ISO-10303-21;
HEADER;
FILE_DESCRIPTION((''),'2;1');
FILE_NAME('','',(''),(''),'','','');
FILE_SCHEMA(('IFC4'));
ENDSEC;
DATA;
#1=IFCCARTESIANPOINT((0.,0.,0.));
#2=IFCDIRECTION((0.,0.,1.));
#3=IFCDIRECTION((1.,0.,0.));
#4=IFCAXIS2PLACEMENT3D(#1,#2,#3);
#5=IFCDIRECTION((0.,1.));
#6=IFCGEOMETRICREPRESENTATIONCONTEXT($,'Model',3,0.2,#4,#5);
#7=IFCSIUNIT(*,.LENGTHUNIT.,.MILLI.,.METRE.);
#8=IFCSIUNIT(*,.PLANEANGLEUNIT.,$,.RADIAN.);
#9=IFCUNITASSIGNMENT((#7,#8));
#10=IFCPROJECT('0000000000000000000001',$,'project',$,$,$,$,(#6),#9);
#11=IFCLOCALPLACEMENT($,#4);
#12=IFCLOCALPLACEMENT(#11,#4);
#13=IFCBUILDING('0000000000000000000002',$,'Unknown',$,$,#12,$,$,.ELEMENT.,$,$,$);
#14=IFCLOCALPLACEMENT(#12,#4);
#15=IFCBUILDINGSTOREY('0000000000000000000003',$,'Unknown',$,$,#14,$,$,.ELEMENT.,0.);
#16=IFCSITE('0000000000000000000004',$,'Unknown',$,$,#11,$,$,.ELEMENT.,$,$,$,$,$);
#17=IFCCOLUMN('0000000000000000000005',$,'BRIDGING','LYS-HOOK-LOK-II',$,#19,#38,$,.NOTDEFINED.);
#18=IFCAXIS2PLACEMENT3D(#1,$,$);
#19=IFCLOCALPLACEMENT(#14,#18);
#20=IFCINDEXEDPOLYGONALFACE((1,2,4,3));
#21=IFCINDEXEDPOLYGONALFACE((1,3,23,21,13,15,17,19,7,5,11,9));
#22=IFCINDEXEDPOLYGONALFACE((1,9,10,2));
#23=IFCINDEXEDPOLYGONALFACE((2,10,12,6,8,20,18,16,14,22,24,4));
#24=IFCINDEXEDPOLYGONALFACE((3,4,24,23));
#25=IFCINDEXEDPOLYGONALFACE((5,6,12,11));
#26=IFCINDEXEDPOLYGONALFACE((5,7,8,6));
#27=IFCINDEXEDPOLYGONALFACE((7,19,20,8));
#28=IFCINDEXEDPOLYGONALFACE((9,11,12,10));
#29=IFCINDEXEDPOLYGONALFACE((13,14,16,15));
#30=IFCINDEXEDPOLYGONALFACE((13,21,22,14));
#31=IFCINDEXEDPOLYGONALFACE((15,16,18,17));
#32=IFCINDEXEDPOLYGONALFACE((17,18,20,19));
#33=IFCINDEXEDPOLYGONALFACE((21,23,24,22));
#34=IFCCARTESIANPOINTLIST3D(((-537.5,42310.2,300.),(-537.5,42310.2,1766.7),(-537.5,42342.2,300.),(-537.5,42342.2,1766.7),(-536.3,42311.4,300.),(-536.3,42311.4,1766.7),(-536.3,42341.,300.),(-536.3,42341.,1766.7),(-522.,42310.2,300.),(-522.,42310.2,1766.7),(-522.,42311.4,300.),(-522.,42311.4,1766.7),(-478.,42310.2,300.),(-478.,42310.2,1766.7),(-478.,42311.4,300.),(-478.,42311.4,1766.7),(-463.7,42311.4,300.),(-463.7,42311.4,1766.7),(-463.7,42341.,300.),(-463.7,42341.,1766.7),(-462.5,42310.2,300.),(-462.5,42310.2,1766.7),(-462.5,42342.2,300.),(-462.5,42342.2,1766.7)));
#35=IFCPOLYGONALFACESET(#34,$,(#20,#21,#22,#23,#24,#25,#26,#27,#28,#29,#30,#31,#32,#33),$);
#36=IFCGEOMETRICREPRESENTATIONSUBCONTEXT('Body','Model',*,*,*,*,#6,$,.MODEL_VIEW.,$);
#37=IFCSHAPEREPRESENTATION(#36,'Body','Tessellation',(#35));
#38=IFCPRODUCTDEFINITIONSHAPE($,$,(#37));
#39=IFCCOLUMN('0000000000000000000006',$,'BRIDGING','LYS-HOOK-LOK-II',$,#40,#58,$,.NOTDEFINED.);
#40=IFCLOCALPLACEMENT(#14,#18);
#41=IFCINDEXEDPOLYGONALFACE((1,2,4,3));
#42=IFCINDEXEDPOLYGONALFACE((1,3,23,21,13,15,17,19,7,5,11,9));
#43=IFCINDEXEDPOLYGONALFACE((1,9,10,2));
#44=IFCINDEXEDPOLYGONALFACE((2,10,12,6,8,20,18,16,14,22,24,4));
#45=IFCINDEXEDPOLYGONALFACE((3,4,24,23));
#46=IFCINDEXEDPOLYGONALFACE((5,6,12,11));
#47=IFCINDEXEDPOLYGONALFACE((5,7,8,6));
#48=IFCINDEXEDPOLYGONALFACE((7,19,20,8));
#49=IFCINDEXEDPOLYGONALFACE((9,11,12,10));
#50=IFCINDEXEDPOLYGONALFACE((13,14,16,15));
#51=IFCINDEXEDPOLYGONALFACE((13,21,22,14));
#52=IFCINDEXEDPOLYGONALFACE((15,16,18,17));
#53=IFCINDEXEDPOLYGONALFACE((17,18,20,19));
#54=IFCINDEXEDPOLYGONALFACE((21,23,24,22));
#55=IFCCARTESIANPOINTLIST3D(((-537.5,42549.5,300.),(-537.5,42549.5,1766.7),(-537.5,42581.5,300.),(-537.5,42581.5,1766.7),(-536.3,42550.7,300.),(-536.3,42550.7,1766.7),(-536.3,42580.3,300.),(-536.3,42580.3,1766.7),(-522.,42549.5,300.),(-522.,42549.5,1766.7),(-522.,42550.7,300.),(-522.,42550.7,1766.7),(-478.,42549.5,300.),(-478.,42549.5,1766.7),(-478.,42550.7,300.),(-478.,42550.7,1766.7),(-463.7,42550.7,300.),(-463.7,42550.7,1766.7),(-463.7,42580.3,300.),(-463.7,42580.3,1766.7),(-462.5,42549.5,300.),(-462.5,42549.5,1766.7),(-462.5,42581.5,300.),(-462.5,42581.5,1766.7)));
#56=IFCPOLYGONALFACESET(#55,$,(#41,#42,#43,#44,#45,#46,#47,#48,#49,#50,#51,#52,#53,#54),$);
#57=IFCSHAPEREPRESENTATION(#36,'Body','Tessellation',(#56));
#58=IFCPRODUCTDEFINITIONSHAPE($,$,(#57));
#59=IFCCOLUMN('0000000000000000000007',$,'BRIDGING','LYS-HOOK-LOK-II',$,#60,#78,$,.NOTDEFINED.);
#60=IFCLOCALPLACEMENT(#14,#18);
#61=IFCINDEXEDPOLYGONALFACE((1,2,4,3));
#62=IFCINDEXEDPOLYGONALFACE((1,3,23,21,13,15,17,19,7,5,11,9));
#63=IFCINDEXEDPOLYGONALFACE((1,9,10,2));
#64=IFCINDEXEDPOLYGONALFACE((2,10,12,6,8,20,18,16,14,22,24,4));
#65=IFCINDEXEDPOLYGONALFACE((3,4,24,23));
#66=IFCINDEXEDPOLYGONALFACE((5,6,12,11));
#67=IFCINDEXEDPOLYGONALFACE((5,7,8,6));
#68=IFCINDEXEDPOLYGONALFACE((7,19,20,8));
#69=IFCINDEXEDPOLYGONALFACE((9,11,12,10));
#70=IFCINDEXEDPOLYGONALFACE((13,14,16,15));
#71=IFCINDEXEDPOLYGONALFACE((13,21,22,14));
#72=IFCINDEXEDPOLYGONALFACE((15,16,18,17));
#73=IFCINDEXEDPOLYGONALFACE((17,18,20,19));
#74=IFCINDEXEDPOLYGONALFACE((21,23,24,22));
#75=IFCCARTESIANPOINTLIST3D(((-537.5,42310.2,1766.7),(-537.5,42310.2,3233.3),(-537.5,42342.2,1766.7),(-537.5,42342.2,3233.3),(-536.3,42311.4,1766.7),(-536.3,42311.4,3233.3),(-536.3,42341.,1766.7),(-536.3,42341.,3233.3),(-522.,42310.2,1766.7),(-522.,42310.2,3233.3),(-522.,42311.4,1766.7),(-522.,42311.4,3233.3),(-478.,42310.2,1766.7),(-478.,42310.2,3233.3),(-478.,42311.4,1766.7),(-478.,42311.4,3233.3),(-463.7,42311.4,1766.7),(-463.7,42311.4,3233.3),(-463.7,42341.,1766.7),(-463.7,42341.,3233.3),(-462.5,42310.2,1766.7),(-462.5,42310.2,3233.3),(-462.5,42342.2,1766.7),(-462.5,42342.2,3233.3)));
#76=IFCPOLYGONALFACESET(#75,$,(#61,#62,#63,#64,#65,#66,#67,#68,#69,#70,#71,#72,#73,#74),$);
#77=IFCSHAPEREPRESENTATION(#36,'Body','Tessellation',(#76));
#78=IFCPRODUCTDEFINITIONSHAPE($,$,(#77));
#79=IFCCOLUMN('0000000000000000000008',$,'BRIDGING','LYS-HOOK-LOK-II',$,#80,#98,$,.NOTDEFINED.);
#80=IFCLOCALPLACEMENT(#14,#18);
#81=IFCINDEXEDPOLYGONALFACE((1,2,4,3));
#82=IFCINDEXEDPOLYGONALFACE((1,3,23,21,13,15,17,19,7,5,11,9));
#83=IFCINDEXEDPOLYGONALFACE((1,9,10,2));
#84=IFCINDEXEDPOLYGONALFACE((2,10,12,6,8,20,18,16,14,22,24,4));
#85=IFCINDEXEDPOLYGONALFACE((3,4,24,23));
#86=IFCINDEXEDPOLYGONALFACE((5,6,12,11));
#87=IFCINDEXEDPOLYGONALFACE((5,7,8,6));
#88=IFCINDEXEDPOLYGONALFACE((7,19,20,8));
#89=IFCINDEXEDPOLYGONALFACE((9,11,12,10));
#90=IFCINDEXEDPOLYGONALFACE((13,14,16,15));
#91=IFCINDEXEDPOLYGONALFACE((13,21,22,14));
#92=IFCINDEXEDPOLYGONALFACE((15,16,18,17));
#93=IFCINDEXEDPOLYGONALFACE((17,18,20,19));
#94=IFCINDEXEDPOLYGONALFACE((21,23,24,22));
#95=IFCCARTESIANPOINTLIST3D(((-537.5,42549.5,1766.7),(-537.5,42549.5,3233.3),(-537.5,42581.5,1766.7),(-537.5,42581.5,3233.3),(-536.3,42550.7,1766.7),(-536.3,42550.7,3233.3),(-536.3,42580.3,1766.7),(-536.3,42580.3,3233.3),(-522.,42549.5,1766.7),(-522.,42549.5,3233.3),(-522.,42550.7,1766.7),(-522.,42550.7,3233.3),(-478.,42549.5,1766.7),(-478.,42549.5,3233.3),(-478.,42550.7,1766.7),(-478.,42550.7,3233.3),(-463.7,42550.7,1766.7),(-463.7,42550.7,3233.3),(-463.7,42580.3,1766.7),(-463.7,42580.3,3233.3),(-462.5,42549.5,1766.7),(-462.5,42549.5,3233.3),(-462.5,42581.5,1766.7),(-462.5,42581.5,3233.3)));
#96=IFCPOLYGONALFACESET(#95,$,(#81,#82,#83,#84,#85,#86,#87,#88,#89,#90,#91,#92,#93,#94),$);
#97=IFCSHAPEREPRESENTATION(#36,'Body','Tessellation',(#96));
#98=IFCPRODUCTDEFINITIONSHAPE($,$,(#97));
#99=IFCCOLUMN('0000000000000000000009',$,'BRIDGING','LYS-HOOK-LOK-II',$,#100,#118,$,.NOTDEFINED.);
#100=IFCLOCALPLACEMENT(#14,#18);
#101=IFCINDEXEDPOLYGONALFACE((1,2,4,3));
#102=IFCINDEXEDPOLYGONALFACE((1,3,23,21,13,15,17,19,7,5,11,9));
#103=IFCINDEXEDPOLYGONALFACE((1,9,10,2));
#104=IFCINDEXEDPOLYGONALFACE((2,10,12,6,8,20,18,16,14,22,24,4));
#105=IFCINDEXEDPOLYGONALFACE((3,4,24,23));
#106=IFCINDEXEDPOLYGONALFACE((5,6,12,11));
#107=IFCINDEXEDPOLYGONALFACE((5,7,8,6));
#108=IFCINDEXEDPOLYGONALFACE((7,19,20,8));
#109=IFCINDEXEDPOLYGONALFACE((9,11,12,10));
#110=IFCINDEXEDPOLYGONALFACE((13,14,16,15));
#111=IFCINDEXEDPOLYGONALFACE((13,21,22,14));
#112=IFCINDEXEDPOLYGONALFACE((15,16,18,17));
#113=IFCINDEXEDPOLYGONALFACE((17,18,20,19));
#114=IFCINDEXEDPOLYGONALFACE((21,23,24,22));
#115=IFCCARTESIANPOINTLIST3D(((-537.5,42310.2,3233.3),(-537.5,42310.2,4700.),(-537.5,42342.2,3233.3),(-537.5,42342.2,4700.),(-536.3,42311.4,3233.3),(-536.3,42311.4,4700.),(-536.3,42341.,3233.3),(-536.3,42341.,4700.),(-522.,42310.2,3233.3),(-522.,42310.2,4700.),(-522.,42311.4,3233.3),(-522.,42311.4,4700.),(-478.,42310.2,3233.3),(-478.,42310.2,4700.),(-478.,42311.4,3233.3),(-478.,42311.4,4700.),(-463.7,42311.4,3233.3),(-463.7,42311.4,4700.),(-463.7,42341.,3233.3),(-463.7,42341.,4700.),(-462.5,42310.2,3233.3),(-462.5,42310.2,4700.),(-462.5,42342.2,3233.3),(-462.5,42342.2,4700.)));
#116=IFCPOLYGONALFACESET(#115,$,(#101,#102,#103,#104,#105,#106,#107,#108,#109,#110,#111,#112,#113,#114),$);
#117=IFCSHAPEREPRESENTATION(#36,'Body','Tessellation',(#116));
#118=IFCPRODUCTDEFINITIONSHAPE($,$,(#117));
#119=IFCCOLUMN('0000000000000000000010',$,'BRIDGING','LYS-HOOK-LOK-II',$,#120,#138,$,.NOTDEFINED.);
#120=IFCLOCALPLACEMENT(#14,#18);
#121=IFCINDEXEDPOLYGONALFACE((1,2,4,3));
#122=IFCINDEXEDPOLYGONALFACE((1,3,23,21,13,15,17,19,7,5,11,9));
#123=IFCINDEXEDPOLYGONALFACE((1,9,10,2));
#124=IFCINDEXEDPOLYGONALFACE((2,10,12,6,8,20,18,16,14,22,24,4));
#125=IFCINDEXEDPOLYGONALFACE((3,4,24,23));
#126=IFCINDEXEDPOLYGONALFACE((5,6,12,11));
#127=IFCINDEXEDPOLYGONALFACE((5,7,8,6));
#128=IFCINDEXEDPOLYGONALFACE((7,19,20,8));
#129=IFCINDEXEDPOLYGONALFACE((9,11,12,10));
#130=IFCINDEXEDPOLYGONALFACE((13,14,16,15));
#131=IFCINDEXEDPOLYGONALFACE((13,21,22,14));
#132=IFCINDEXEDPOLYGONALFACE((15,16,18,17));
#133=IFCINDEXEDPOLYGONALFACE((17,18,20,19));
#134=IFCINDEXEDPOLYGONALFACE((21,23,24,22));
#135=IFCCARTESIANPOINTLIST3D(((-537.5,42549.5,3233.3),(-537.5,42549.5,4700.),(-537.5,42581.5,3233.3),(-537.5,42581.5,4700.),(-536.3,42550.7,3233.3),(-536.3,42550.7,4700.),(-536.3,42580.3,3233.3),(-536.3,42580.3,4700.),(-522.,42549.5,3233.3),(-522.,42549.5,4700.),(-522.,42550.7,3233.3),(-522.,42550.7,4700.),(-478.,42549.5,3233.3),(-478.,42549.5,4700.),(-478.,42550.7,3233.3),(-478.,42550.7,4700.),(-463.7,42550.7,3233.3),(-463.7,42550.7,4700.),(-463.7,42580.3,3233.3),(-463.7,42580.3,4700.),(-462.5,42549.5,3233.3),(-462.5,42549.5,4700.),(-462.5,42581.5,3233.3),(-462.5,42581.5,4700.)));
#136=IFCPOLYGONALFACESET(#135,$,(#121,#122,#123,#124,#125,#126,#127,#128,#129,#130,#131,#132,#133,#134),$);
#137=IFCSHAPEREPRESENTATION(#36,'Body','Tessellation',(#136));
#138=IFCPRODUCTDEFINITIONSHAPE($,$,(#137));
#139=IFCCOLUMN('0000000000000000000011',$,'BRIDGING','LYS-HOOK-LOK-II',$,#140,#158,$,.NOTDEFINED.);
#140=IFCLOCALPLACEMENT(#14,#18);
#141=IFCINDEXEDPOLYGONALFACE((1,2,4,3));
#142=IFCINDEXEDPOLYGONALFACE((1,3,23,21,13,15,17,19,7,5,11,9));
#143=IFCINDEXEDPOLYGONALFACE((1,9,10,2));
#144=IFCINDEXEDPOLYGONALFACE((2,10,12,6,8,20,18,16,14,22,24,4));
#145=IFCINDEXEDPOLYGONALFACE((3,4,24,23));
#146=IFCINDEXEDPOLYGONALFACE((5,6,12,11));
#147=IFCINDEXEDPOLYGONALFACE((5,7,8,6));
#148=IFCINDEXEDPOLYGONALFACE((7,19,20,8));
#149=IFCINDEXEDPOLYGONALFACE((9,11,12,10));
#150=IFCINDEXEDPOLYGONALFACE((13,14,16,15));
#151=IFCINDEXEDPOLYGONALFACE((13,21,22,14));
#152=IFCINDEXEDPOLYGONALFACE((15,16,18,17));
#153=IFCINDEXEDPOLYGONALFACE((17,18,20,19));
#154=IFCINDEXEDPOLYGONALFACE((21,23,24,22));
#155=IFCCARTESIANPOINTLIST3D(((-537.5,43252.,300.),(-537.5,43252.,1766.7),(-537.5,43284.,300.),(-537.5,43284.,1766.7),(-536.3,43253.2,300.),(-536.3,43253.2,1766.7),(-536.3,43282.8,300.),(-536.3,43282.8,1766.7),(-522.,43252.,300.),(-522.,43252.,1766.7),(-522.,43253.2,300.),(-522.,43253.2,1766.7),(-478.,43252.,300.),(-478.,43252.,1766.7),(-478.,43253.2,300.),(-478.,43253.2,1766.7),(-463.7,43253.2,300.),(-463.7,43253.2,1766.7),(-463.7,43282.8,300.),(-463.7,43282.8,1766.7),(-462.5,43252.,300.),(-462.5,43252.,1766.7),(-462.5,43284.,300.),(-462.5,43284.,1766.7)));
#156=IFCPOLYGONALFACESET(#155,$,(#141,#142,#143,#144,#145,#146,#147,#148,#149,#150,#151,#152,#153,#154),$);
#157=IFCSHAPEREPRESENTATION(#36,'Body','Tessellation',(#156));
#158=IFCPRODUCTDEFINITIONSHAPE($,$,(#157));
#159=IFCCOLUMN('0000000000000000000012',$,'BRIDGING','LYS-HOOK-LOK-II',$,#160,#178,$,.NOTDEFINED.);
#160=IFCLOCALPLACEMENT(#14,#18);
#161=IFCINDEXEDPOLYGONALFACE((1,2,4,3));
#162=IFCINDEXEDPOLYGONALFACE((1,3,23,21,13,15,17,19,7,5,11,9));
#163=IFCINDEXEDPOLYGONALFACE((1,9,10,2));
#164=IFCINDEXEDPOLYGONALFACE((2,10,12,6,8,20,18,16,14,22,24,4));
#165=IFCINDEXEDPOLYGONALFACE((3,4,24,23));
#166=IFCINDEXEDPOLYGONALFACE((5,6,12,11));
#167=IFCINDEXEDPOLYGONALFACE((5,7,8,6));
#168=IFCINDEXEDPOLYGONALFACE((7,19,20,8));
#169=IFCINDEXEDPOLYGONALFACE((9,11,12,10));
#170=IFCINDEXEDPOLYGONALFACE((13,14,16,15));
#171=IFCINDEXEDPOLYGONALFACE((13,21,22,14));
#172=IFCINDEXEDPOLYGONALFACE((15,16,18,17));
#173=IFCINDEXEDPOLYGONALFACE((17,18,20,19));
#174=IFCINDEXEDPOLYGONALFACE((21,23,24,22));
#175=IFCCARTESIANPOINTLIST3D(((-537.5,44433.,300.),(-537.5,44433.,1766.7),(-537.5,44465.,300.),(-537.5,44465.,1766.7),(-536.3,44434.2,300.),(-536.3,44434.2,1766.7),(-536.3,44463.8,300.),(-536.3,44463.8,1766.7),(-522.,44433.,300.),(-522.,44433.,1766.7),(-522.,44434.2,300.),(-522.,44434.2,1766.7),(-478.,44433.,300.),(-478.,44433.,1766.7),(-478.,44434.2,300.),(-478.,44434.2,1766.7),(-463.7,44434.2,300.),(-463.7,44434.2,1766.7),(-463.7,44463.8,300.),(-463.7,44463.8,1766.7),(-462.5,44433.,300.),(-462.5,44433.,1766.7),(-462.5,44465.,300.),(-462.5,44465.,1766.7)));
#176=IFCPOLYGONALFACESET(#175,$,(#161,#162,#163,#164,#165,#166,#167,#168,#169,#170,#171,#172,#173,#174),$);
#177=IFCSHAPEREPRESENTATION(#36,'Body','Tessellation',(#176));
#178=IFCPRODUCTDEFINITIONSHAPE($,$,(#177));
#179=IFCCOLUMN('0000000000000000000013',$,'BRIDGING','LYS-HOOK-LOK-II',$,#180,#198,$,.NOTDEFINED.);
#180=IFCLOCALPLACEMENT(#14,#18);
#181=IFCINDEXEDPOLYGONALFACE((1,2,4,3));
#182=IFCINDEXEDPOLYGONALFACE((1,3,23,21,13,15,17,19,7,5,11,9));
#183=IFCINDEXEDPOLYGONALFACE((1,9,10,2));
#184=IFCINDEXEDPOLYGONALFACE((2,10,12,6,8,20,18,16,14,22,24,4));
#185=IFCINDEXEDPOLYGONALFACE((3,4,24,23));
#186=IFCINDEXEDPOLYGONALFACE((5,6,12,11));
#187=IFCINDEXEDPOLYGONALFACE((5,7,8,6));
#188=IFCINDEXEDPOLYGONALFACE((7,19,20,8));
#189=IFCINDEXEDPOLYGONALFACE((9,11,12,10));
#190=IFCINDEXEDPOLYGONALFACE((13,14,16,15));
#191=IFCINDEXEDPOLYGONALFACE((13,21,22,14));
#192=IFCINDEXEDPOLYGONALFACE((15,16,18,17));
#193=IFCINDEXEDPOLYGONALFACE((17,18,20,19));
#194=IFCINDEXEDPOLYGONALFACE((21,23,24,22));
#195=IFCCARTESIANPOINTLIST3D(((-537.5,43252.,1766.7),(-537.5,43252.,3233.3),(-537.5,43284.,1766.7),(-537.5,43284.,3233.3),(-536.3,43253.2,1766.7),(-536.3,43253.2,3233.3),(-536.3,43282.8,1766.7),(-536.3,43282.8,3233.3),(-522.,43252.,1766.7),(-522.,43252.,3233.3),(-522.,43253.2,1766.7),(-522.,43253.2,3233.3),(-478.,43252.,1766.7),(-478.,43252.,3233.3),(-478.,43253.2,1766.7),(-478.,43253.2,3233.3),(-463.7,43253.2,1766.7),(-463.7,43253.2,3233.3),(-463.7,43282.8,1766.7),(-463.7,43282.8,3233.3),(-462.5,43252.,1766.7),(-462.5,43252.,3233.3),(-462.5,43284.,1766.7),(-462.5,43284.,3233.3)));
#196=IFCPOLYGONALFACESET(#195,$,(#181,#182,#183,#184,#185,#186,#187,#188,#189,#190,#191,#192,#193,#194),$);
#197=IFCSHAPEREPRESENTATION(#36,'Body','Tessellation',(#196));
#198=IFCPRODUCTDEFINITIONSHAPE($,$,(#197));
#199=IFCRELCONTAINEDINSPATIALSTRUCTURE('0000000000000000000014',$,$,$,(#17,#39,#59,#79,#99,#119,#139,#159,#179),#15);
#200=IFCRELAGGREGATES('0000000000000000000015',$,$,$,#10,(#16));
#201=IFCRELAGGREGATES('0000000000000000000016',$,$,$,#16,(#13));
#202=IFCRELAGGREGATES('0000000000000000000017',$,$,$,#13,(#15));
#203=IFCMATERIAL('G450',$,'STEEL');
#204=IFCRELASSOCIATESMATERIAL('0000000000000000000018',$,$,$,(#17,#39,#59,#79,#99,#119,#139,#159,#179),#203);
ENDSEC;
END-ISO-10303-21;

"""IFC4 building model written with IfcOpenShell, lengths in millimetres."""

from ifc_helpers import new_model, si_unit, direction, frame, origin_with_axes, place, context, subcontext, project, spatial, line, indexed_curve, outline, extrude, material, element, save


model = new_model("IFC4")

# Units and contexts
model_context = context("Model", 3, precision=0.2, world=origin_with_axes(), true_north=direction((0.0, 1.0)))
body_context = subcontext(model_context, "Body", "Model", "MODEL_VIEW")
ifc_project = project(units=[si_unit("LENGTHUNIT", "METRE", prefix="MILLI"), si_unit("PLANEANGLEUNIT", "RADIAN")], contexts=[model_context])

# Site, building, storey
site_placement = place(None, origin_with_axes())
site = spatial("IfcSite", under=ifc_project, at=site_placement, Name="Unknown", CompositionType="ELEMENT")
building_placement = place(site_placement, origin_with_axes())
building = spatial("IfcBuilding", under=site, at=building_placement, Name="Unknown", CompositionType="ELEMENT")
storey_placement = place(building_placement, origin_with_axes())
storey = spatial("IfcBuildingStorey", under=building, at=storey_placement, Name="Unknown", CompositionType="ELEMENT", Elevation=0.0)

# Columns
ifc_material_1 = material(Name="G450", Category="STEEL")
for number, where, z_axis, x_axis, name in (
    (1, (-500.0, 42326.2, 300.0), (0.0, -1.0, 0.0), (0.0, 0.0, 1.0), "BRIDGING"),
    (2, (-500.0, 42565.5, 300.0), (0.0, -1.0, 0.0), (0.0, 0.0, 1.0), "BRIDGING"),
):
    element("IfcColumn", number, at=place(storey_placement, frame(where, z_axis=z_axis, x_axis=x_axis)), inside=storey, material=ifc_material_1, Name=name, Description="LYS-HOOK-LOK-II", PredefinedType="NOTDEFINED", context=body_context, shape_type="SolidModel", body=[
        extrude(outline(indexed_curve([(16.0, -37.5), (16.0, -22.0), (14.8, -22.0), (14.8, -36.3), (-14.8, -36.3), (-14.8, 36.3), (14.8, 36.3), (14.8, 22.0), (16.0, 22.0), (16.0, 37.5), (-16.0, 37.5), (-16.0, -37.5)], segments=[line(1, 2, 3, 4, 5, 6, 7, 8, 9, 10, 11, 12, 1)])), frame((0.0, 0.0, 0.0), z_axis=(-1.0, 0.0, 0.0), x_axis=(0.0, 0.0, 1.0)), (0.0, 0.0, -1.0), 1466.7),
    ])
for number, where, z_axis, x_axis, name in (
    (3, (-500.0, 42326.2, 1766.7), (0.0, -1.0, 0.0), (0.0, 0.0, 1.0), "BRIDGING"),
    (4, (-500.0, 42565.5, 1766.7), (0.0, -1.0, 0.0), (0.0, 0.0, 1.0), "BRIDGING"),
):
    element("IfcColumn", number, at=place(storey_placement, frame(where, z_axis=z_axis, x_axis=x_axis)), inside=storey, material=ifc_material_1, Name=name, Description="LYS-HOOK-LOK-II", PredefinedType="NOTDEFINED", context=body_context, shape_type="SolidModel", body=[
        extrude(outline(indexed_curve([(16.0, -37.5), (16.0, -22.0), (14.8, -22.0), (14.8, -36.3), (-14.8, -36.3), (-14.8, 36.3), (14.8, 36.3), (14.8, 22.0), (16.0, 22.0), (16.0, 37.5), (-16.0, 37.5), (-16.0, -37.5)], segments=[line(1, 2, 3, 4, 5, 6, 7, 8, 9, 10, 11, 12, 1)])), frame((0.0, 0.0, 0.0), z_axis=(-1.0, 0.0, 0.0), x_axis=(0.0, 0.0, 1.0)), (0.0, 0.0, -1.0), 1466.6),
    ])
for number, where, z_axis, x_axis, name in (
    (5, (-500.0, 42326.2, 3233.3), (0.0, -1.0, 0.0), (0.0, 0.0, 1.0), "BRIDGING"),
    (6, (-500.0, 42565.5, 3233.3), (0.0, -1.0, 0.0), (0.0, 0.0, 1.0), "BRIDGING"),
    (7, (-500.0, 43268.0, 300.0), (0.0, -1.0, 0.0), (0.0, 0.0, 1.0), "BRIDGING"),
    (8, (-500.0, 44449.0, 300.0), (0.0, -1.0, 0.0), (0.0, 0.0, 1.0), "BRIDGING"),
):
    element("IfcColumn", number, at=place(storey_placement, frame(where, z_axis=z_axis, x_axis=x_axis)), inside=storey, material=ifc_material_1, Name=name, Description="LYS-HOOK-LOK-II", PredefinedType="NOTDEFINED", context=body_context, shape_type="SolidModel", body=[
        extrude(outline(indexed_curve([(16.0, -37.5), (16.0, -22.0), (14.8, -22.0), (14.8, -36.3), (-14.8, -36.3), (-14.8, 36.3), (14.8, 36.3), (14.8, 22.0), (16.0, 22.0), (16.0, 37.5), (-16.0, 37.5), (-16.0, -37.5)], segments=[line(1, 2, 3, 4, 5, 6, 7, 8, 9, 10, 11, 12, 1)])), frame((0.0, 0.0, 0.0), z_axis=(-1.0, 0.0, 0.0), x_axis=(0.0, 0.0, 1.0)), (0.0, 0.0, -1.0), 1466.7),
    ])
for number, where, z_axis, x_axis, name in (
    (9, (-500.0, 43268.0, 1766.7), (0.0, -1.0, 0.0), (0.0, 0.0, 1.0), "BRIDGING"),
):
    element("IfcColumn", number, at=place(storey_placement, frame(where, z_axis=z_axis, x_axis=x_axis)), inside=storey, material=ifc_material_1, Name=name, Description="LYS-HOOK-LOK-II", PredefinedType="NOTDEFINED", context=body_context, shape_type="SolidModel", body=[
        extrude(outline(indexed_curve([(16.0, -37.5), (16.0, -22.0), (14.8, -22.0), (14.8, -36.3), (-14.8, -36.3), (-14.8, 36.3), (14.8, 36.3), (14.8, 22.0), (16.0, 22.0), (16.0, 37.5), (-16.0, 37.5), (-16.0, -37.5)], segments=[line(1, 2, 3, 4, 5, 6, 7, 8, 9, 10, 11, 12, 1)])), frame((0.0, 0.0, 0.0), z_axis=(-1.0, 0.0, 0.0), x_axis=(0.0, 0.0, 1.0)), (0.0, 0.0, -1.0), 1466.6),
    ])

save(model, "model.ifc")
